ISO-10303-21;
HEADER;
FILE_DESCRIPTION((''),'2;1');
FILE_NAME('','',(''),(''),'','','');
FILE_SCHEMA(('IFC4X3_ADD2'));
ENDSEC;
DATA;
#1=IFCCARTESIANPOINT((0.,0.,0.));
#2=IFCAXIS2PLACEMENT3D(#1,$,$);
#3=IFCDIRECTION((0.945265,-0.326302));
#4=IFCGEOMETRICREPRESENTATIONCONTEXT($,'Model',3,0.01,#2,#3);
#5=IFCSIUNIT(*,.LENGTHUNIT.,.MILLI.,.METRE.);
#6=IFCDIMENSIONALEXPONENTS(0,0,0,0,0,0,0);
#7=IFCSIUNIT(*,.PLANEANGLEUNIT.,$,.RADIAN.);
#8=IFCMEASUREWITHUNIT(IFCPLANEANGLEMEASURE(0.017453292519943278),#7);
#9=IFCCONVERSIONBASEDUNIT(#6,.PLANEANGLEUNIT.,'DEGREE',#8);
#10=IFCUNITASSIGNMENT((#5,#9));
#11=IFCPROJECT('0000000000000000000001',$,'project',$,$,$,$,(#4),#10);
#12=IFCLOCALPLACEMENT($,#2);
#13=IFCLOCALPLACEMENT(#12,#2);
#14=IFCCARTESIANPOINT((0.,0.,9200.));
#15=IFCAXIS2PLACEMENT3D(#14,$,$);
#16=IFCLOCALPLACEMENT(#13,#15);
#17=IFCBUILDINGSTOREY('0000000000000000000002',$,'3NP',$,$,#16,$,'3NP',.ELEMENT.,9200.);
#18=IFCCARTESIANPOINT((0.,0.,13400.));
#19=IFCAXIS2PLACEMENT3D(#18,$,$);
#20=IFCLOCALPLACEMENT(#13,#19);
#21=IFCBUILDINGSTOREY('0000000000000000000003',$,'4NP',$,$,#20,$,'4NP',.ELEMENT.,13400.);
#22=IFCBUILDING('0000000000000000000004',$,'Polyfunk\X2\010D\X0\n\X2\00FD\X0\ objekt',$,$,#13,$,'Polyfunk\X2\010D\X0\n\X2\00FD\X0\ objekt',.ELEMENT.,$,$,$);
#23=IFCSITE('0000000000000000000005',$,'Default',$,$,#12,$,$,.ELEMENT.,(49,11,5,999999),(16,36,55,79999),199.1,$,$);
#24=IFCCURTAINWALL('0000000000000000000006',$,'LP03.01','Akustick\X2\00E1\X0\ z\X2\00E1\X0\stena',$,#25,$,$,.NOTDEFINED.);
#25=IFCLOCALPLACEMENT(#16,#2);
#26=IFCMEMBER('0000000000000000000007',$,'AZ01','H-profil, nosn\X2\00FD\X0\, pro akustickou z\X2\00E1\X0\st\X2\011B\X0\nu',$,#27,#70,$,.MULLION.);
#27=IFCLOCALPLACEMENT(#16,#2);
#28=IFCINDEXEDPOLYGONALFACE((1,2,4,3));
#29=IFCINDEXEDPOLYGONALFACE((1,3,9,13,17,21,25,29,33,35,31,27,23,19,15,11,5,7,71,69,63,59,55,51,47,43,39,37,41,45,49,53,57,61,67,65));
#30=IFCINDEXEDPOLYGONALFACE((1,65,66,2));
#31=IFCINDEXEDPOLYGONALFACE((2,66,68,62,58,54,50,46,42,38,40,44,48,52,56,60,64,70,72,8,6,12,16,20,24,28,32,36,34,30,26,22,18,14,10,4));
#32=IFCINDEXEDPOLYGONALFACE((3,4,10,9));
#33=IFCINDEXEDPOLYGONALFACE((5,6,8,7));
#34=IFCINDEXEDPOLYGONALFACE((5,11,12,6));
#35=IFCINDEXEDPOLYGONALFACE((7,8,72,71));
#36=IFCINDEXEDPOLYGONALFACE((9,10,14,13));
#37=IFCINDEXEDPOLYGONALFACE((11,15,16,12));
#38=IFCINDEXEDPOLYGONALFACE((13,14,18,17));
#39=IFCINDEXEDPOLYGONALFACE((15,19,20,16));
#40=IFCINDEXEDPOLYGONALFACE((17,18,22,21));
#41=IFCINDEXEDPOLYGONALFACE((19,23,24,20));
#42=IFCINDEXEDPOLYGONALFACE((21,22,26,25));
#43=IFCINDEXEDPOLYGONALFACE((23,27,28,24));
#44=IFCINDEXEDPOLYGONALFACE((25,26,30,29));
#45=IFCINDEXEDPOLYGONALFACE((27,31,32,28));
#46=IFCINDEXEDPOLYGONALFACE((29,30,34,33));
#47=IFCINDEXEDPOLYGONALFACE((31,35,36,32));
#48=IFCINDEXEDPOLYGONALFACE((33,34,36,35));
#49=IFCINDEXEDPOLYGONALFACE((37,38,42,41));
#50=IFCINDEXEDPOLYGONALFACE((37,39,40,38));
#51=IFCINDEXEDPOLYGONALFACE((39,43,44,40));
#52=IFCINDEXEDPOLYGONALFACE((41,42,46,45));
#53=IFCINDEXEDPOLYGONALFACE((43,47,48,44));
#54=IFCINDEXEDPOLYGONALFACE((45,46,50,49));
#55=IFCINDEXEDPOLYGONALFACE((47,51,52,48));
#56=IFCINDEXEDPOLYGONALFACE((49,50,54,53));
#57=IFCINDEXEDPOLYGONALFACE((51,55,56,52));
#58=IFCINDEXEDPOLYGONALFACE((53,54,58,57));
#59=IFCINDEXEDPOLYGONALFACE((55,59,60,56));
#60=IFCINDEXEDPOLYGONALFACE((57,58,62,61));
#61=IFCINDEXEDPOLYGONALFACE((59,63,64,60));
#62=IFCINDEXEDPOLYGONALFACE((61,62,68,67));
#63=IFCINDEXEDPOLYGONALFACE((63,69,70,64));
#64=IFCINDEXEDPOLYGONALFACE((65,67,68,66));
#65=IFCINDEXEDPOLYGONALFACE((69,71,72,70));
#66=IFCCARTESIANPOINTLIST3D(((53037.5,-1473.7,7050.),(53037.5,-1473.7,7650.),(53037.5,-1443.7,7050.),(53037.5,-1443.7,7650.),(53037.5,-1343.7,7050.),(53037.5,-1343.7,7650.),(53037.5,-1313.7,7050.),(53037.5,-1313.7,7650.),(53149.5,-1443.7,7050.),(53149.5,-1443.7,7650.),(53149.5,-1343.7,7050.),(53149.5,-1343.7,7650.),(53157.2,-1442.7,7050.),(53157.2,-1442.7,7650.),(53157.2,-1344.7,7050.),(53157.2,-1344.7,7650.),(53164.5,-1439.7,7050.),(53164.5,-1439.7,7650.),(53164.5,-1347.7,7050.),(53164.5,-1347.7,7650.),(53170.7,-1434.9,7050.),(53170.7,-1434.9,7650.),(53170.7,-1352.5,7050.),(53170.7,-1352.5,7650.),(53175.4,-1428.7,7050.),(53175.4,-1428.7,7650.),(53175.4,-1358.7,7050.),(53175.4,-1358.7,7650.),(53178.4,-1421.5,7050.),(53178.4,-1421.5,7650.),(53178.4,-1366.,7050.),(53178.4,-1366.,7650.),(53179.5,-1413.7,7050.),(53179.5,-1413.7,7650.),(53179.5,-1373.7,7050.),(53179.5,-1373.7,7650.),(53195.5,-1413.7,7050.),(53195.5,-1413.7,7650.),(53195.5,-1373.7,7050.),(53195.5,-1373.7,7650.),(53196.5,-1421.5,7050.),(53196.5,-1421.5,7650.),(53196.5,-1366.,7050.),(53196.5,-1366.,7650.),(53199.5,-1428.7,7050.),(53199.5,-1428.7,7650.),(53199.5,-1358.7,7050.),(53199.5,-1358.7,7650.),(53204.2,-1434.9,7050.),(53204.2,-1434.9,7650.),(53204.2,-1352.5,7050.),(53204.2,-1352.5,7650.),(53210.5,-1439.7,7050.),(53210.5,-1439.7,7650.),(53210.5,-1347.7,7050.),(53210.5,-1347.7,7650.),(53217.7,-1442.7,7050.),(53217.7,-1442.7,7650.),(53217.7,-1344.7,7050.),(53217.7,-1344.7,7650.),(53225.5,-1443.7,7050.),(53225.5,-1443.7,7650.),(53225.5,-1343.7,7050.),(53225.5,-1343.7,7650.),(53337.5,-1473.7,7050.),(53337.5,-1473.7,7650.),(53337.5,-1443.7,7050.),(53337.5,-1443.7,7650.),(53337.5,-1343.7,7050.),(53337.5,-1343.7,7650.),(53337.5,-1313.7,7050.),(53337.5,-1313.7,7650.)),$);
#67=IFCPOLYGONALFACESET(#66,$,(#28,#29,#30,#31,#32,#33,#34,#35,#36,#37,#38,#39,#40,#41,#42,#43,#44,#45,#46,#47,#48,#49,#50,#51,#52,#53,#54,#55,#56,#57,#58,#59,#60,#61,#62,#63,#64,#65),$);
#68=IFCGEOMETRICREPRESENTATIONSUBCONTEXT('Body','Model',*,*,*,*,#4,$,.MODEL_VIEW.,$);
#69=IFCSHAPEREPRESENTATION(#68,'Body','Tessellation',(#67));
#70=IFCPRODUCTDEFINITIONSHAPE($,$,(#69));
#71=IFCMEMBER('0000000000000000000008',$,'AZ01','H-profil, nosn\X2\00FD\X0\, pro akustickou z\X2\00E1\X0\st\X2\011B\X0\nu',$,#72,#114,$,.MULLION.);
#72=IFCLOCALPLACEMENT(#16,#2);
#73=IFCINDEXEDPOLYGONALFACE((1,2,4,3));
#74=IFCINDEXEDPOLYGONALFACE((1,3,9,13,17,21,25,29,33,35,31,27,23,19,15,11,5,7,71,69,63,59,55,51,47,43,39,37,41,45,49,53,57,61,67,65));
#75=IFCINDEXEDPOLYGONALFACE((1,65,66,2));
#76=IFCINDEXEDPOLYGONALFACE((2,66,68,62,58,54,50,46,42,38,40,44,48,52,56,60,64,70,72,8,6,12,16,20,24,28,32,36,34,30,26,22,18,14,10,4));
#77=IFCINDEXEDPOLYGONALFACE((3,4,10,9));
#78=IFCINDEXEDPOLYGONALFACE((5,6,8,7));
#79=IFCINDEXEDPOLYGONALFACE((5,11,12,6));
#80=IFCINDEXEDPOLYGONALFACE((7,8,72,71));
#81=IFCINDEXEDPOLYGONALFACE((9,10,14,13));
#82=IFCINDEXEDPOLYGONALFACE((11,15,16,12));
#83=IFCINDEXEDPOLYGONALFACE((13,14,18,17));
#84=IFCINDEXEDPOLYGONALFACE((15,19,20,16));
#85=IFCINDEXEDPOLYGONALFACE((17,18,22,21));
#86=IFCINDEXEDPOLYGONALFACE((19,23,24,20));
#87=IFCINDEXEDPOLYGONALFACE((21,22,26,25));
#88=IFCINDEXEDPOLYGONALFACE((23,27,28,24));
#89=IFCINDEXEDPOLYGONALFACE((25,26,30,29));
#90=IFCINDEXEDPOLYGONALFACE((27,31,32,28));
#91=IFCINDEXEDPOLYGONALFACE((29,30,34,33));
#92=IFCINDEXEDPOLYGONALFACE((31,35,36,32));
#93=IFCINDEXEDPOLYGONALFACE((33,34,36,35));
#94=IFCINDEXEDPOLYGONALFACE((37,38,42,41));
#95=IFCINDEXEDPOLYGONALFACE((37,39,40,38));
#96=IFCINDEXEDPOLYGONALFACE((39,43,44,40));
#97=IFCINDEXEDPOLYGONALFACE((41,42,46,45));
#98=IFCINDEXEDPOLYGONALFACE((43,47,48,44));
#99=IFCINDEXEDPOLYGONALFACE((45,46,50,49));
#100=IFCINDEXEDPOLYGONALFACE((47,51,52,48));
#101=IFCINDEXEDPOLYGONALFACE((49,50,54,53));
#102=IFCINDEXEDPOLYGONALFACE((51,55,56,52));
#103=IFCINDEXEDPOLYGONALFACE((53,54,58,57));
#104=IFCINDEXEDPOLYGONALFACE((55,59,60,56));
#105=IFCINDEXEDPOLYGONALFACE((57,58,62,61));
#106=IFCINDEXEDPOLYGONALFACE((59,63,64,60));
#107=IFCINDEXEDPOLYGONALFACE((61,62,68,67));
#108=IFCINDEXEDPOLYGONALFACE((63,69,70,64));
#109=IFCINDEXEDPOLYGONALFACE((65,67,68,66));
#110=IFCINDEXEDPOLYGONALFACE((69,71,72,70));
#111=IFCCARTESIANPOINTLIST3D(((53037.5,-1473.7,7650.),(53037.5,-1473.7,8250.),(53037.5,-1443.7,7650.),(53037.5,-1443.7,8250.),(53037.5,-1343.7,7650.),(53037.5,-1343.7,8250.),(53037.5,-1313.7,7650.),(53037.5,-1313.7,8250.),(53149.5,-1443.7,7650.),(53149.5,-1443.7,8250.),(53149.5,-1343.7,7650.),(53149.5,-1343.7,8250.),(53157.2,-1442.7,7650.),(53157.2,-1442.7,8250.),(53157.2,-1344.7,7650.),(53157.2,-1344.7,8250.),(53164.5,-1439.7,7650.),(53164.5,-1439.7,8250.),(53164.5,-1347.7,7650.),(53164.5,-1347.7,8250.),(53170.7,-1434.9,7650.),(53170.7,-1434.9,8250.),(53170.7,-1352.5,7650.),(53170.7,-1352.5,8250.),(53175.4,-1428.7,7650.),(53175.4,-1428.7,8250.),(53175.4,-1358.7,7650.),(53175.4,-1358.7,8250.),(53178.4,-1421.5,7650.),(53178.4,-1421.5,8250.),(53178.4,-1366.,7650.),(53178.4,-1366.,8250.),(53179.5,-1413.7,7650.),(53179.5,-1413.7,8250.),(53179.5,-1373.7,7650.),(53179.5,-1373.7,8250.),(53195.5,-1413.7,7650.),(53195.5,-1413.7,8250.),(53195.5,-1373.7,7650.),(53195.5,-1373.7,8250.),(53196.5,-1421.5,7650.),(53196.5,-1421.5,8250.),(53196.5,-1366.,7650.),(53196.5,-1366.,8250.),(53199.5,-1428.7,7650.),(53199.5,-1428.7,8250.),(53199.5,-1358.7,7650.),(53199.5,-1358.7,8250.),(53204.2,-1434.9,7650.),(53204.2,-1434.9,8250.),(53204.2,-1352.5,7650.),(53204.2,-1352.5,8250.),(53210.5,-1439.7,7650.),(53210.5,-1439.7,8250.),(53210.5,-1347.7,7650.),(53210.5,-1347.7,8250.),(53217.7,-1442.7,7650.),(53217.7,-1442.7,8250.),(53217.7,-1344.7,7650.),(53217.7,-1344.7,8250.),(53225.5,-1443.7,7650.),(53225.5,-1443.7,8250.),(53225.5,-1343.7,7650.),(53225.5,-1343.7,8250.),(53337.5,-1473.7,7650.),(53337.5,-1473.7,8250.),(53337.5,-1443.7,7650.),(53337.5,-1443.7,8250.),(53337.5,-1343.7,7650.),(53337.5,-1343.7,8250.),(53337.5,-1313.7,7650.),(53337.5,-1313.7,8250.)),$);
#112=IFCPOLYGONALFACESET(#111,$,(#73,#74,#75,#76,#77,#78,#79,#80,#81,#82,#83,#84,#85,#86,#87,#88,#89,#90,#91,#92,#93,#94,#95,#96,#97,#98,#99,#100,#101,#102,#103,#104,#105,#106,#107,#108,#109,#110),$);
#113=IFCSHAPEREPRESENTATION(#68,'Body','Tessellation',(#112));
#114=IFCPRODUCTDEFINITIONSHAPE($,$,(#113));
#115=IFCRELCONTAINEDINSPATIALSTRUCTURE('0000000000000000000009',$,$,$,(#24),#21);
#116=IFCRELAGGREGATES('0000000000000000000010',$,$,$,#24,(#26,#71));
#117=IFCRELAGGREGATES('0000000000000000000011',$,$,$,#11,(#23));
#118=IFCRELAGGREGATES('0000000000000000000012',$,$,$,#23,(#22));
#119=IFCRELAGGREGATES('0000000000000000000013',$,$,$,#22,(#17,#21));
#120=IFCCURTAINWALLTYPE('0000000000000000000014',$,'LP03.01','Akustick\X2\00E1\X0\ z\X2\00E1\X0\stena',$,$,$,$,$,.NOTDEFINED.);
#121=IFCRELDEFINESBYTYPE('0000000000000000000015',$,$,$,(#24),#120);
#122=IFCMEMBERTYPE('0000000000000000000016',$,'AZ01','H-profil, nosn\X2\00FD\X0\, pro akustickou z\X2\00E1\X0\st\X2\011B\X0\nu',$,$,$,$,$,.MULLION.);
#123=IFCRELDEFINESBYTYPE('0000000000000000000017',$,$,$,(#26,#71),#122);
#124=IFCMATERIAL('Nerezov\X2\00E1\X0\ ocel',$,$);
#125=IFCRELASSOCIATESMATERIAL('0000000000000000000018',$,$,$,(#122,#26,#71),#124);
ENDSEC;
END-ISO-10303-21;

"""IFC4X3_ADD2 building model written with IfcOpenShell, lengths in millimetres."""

from ifc_helpers import new_model, entity, si_unit, converted_unit, direction, frame, frame_2d, origin, place, context, subcontext, project, spatial, polyline, circle_curve, parameter, trimmed, segment, composite_curve, outline, extrude, source, transform, mapped, material, material_profile, profile_set, profile_usage, type_object, element, aggregate, save


model = new_model("IFC4X3_ADD2")

# Units and contexts
model_context = context("Model", 3, precision=0.01, world=origin(), true_north=direction((0.945265, -0.326302)))
body_context = subcontext(model_context, "Body", "Model", "MODEL_VIEW")
ifc_project = project(units=[si_unit("LENGTHUNIT", "METRE", prefix="MILLI"), converted_unit("PLANEANGLEUNIT", "DEGREE", entity("IfcPlaneAngleMeasure", 0.017453292519943278), si_unit("PLANEANGLEUNIT", "RADIAN"), dimensions=[0, 0, 0, 0, 0, 0, 0])], contexts=[model_context])

# Site, building, storey
site_placement = place(None, origin())
site = spatial("IfcSite", under=ifc_project, at=site_placement, Name="Default", CompositionType="ELEMENT", RefLatitude=(49, 11, 5, 999999), RefLongitude=(16, 36, 55, 79999), RefElevation=199.1)
building_placement = place(site_placement, origin())
building = spatial("IfcBuilding", under=site, at=building_placement, Name="Polyfunkčný objekt", LongName="Polyfunkčný objekt", CompositionType="ELEMENT")
storey_1_placement = place(building_placement, frame((0.0, 0.0, 9200.0)))
storey_1 = spatial("IfcBuildingStorey", under=building, at=storey_1_placement, Name="3NP", LongName="3NP", CompositionType="ELEMENT", Elevation=9200.0)

# Shared definitions
storey_2_placement = place(building_placement, frame((0.0, 0.0, 13400.0)))
storey_2 = spatial("IfcBuildingStorey", under=building, at=storey_2_placement, Name="4NP", LongName="4NP", CompositionType="ELEMENT", Elevation=13400.0)

# Curtain wall, members
curtain_wall_type_1 = type_object("IfcCurtainWallType", Name="LP03.01", Description="Akustická zástena", PredefinedType="NOTDEFINED")
curtain_wall_1_placement = place(storey_2_placement, frame((0.0, 0.0, -13400.0)))
curtain_wall_1 = element("IfcCurtainWall", 1, at=curtain_wall_1_placement, inside=storey_2, type_object=curtain_wall_type_1, Name="LP03.01", Description="Akustická zástena", PredefinedType="NOTDEFINED")
ifc_material_1 = material(Name="Nerezová ocel")
ifc_material_profile_1 = material_profile(ifc_material_1, outline(composite_curve([segment(polyline([(50.0, -150.0), (80.0, -150.0)]), True, "CONTINUOUS"), segment(polyline([(80.0, -150.0), (80.0, 150.0)]), True, "CONTINUOUS"), segment(polyline([(80.0, 150.0), (50.0, 150.0)]), True, "CONTINUOUS"), segment(polyline([(50.0, 150.0), (50.0, 38.0)]), True, "CONTINUOUS"), segment(trimmed(circle_curve(frame_2d((20.0, 38.0), x_axis=(0.0, 1.0)), 30.0), [parameter(180.0)], [parameter(270.0)], True, "PARAMETER"), False, "CONTINUOUS"), segment(polyline([(20.0, 8.0), (-20.0, 8.0)]), True, "CONTINUOUS"), segment(trimmed(circle_curve(frame_2d((-20.0, 38.0), x_axis=(0.0, 1.0)), 30.0), [parameter(90.0)], [parameter(180.0)], True, "PARAMETER"), False, "CONTINUOUS"), segment(polyline([(-50.0, 38.0), (-50.0, 150.0)]), True, "CONTINUOUS"), segment(polyline([(-50.0, 150.0), (-80.0, 150.0)]), True, "CONTINUOUS"), segment(polyline([(-80.0, 150.0), (-80.0, -150.0)]), True, "CONTINUOUS"), segment(polyline([(-80.0, -150.0), (-50.0, -150.0)]), True, "CONTINUOUS"), segment(polyline([(-50.0, -150.0), (-50.0, -38.0)]), True, "CONTINUOUS"), segment(trimmed(circle_curve(frame_2d((-20.0, -38.0), x_axis=(0.0, 1.0)), 30.0), [parameter(0.0)], [parameter(90.0)], True, "PARAMETER"), False, "CONTINUOUS"), segment(polyline([(-20.0, -8.0), (20.0, -8.0)]), True, "CONTINUOUS"), segment(trimmed(circle_curve(frame_2d((20.0, -38.0), x_axis=(0.0, 1.0)), 30.0), [parameter(270.0)], [parameter(0.0)], True, "PARAMETER"), False, "CONTINUOUS"), segment(polyline([(50.0, -38.0), (50.0, -150.0)]), True, "CONTINUOUS")], self_intersect=False)), Name="Profil zástena")
ifc_profile_set_1 = profile_set([ifc_material_profile_1], Name="Profil zástena")
ifc_profile_usage_1 = profile_usage(ifc_profile_set_1)
member_type_1 = type_object("IfcMemberType", Name="AZ01", Description="H-profil, nosný, pro akustickou zástěnu", PredefinedType="MULLION", material=ifc_profile_set_1)
shared_shape_1 = source(origin(), body_context, "Body", "SweptSolid", [
    extrude(outline(composite_curve([segment(polyline([(50.0, -150.0), (80.0, -150.0)]), True, "CONTINUOUS"), segment(polyline([(80.0, -150.0), (80.0, 150.0)]), True, "CONTINUOUS"), segment(polyline([(80.0, 150.0), (50.0, 150.0)]), True, "CONTINUOUS"), segment(polyline([(50.0, 150.0), (50.0, 38.0)]), True, "CONTINUOUS"), segment(trimmed(circle_curve(frame_2d((20.0, 38.0), x_axis=(0.0, 1.0)), 30.0), [parameter(180.0)], [parameter(270.0)], True, "PARAMETER"), False, "CONTINUOUS"), segment(polyline([(20.0, 8.0), (-20.0, 8.0)]), True, "CONTINUOUS"), segment(trimmed(circle_curve(frame_2d((-20.0, 38.0), x_axis=(0.0, 1.0)), 30.0), [parameter(90.0)], [parameter(180.0)], True, "PARAMETER"), False, "CONTINUOUS"), segment(polyline([(-50.0, 38.0), (-50.0, 150.0)]), True, "CONTINUOUS"), segment(polyline([(-50.0, 150.0), (-80.0, 150.0)]), True, "CONTINUOUS"), segment(polyline([(-80.0, 150.0), (-80.0, -150.0)]), True, "CONTINUOUS"), segment(polyline([(-80.0, -150.0), (-50.0, -150.0)]), True, "CONTINUOUS"), segment(polyline([(-50.0, -150.0), (-50.0, -38.0)]), True, "CONTINUOUS"), segment(trimmed(circle_curve(frame_2d((-20.0, -38.0), x_axis=(0.0, 1.0)), 30.0), [parameter(0.0)], [parameter(90.0)], True, "PARAMETER"), False, "CONTINUOUS"), segment(polyline([(-20.0, -8.0), (20.0, -8.0)]), True, "CONTINUOUS"), segment(trimmed(circle_curve(frame_2d((20.0, -38.0), x_axis=(0.0, 1.0)), 30.0), [parameter(270.0)], [parameter(0.0)], True, "PARAMETER"), False, "CONTINUOUS"), segment(polyline([(50.0, -38.0), (50.0, -150.0)]), True, "CONTINUOUS")], self_intersect=False)), frame((0.0, 0.0, -600.0), z_axis=(0.0, 0.0, 1.0), x_axis=(0.0, -1.0, 0.0)), (0.0, 0.0, 1.0), 600.0),
])
member_1_placement = place(curtain_wall_1_placement, frame((53187.5, -1393.7, 16250.0), z_axis=(0.0, 0.0, -1.0), x_axis=(1.0, 0.0, 0.0)))
member_1 = element("IfcMember", 2, at=member_1_placement, type_object=member_type_1, material=ifc_profile_usage_1, Name="AZ01", Description="H-profil, nosný, pro akustickou zástěnu", PredefinedType="MULLION", context=body_context, shape_type="MappedRepresentation", body=[
    mapped(shared_shape_1, transform((0.0, 0.0, 0.0), scale=1.0)),
])
member_2_placement = place(curtain_wall_1_placement, frame((53187.5, -1393.7, 16850.0), z_axis=(0.0, 0.0, -1.0), x_axis=(1.0, 0.0, 0.0)))
member_2 = element("IfcMember", 3, at=member_2_placement, type_object=member_type_1, material=ifc_profile_usage_1, Name="AZ01", Description="H-profil, nosný, pro akustickou zástěnu", PredefinedType="MULLION", context=body_context, shape_type="MappedRepresentation", body=[
    mapped(shared_shape_1, transform((0.0, 0.0, 0.0), scale=1.0)),
])

aggregate(curtain_wall_1, [member_1, member_2])

save(model, "model.ifc")
